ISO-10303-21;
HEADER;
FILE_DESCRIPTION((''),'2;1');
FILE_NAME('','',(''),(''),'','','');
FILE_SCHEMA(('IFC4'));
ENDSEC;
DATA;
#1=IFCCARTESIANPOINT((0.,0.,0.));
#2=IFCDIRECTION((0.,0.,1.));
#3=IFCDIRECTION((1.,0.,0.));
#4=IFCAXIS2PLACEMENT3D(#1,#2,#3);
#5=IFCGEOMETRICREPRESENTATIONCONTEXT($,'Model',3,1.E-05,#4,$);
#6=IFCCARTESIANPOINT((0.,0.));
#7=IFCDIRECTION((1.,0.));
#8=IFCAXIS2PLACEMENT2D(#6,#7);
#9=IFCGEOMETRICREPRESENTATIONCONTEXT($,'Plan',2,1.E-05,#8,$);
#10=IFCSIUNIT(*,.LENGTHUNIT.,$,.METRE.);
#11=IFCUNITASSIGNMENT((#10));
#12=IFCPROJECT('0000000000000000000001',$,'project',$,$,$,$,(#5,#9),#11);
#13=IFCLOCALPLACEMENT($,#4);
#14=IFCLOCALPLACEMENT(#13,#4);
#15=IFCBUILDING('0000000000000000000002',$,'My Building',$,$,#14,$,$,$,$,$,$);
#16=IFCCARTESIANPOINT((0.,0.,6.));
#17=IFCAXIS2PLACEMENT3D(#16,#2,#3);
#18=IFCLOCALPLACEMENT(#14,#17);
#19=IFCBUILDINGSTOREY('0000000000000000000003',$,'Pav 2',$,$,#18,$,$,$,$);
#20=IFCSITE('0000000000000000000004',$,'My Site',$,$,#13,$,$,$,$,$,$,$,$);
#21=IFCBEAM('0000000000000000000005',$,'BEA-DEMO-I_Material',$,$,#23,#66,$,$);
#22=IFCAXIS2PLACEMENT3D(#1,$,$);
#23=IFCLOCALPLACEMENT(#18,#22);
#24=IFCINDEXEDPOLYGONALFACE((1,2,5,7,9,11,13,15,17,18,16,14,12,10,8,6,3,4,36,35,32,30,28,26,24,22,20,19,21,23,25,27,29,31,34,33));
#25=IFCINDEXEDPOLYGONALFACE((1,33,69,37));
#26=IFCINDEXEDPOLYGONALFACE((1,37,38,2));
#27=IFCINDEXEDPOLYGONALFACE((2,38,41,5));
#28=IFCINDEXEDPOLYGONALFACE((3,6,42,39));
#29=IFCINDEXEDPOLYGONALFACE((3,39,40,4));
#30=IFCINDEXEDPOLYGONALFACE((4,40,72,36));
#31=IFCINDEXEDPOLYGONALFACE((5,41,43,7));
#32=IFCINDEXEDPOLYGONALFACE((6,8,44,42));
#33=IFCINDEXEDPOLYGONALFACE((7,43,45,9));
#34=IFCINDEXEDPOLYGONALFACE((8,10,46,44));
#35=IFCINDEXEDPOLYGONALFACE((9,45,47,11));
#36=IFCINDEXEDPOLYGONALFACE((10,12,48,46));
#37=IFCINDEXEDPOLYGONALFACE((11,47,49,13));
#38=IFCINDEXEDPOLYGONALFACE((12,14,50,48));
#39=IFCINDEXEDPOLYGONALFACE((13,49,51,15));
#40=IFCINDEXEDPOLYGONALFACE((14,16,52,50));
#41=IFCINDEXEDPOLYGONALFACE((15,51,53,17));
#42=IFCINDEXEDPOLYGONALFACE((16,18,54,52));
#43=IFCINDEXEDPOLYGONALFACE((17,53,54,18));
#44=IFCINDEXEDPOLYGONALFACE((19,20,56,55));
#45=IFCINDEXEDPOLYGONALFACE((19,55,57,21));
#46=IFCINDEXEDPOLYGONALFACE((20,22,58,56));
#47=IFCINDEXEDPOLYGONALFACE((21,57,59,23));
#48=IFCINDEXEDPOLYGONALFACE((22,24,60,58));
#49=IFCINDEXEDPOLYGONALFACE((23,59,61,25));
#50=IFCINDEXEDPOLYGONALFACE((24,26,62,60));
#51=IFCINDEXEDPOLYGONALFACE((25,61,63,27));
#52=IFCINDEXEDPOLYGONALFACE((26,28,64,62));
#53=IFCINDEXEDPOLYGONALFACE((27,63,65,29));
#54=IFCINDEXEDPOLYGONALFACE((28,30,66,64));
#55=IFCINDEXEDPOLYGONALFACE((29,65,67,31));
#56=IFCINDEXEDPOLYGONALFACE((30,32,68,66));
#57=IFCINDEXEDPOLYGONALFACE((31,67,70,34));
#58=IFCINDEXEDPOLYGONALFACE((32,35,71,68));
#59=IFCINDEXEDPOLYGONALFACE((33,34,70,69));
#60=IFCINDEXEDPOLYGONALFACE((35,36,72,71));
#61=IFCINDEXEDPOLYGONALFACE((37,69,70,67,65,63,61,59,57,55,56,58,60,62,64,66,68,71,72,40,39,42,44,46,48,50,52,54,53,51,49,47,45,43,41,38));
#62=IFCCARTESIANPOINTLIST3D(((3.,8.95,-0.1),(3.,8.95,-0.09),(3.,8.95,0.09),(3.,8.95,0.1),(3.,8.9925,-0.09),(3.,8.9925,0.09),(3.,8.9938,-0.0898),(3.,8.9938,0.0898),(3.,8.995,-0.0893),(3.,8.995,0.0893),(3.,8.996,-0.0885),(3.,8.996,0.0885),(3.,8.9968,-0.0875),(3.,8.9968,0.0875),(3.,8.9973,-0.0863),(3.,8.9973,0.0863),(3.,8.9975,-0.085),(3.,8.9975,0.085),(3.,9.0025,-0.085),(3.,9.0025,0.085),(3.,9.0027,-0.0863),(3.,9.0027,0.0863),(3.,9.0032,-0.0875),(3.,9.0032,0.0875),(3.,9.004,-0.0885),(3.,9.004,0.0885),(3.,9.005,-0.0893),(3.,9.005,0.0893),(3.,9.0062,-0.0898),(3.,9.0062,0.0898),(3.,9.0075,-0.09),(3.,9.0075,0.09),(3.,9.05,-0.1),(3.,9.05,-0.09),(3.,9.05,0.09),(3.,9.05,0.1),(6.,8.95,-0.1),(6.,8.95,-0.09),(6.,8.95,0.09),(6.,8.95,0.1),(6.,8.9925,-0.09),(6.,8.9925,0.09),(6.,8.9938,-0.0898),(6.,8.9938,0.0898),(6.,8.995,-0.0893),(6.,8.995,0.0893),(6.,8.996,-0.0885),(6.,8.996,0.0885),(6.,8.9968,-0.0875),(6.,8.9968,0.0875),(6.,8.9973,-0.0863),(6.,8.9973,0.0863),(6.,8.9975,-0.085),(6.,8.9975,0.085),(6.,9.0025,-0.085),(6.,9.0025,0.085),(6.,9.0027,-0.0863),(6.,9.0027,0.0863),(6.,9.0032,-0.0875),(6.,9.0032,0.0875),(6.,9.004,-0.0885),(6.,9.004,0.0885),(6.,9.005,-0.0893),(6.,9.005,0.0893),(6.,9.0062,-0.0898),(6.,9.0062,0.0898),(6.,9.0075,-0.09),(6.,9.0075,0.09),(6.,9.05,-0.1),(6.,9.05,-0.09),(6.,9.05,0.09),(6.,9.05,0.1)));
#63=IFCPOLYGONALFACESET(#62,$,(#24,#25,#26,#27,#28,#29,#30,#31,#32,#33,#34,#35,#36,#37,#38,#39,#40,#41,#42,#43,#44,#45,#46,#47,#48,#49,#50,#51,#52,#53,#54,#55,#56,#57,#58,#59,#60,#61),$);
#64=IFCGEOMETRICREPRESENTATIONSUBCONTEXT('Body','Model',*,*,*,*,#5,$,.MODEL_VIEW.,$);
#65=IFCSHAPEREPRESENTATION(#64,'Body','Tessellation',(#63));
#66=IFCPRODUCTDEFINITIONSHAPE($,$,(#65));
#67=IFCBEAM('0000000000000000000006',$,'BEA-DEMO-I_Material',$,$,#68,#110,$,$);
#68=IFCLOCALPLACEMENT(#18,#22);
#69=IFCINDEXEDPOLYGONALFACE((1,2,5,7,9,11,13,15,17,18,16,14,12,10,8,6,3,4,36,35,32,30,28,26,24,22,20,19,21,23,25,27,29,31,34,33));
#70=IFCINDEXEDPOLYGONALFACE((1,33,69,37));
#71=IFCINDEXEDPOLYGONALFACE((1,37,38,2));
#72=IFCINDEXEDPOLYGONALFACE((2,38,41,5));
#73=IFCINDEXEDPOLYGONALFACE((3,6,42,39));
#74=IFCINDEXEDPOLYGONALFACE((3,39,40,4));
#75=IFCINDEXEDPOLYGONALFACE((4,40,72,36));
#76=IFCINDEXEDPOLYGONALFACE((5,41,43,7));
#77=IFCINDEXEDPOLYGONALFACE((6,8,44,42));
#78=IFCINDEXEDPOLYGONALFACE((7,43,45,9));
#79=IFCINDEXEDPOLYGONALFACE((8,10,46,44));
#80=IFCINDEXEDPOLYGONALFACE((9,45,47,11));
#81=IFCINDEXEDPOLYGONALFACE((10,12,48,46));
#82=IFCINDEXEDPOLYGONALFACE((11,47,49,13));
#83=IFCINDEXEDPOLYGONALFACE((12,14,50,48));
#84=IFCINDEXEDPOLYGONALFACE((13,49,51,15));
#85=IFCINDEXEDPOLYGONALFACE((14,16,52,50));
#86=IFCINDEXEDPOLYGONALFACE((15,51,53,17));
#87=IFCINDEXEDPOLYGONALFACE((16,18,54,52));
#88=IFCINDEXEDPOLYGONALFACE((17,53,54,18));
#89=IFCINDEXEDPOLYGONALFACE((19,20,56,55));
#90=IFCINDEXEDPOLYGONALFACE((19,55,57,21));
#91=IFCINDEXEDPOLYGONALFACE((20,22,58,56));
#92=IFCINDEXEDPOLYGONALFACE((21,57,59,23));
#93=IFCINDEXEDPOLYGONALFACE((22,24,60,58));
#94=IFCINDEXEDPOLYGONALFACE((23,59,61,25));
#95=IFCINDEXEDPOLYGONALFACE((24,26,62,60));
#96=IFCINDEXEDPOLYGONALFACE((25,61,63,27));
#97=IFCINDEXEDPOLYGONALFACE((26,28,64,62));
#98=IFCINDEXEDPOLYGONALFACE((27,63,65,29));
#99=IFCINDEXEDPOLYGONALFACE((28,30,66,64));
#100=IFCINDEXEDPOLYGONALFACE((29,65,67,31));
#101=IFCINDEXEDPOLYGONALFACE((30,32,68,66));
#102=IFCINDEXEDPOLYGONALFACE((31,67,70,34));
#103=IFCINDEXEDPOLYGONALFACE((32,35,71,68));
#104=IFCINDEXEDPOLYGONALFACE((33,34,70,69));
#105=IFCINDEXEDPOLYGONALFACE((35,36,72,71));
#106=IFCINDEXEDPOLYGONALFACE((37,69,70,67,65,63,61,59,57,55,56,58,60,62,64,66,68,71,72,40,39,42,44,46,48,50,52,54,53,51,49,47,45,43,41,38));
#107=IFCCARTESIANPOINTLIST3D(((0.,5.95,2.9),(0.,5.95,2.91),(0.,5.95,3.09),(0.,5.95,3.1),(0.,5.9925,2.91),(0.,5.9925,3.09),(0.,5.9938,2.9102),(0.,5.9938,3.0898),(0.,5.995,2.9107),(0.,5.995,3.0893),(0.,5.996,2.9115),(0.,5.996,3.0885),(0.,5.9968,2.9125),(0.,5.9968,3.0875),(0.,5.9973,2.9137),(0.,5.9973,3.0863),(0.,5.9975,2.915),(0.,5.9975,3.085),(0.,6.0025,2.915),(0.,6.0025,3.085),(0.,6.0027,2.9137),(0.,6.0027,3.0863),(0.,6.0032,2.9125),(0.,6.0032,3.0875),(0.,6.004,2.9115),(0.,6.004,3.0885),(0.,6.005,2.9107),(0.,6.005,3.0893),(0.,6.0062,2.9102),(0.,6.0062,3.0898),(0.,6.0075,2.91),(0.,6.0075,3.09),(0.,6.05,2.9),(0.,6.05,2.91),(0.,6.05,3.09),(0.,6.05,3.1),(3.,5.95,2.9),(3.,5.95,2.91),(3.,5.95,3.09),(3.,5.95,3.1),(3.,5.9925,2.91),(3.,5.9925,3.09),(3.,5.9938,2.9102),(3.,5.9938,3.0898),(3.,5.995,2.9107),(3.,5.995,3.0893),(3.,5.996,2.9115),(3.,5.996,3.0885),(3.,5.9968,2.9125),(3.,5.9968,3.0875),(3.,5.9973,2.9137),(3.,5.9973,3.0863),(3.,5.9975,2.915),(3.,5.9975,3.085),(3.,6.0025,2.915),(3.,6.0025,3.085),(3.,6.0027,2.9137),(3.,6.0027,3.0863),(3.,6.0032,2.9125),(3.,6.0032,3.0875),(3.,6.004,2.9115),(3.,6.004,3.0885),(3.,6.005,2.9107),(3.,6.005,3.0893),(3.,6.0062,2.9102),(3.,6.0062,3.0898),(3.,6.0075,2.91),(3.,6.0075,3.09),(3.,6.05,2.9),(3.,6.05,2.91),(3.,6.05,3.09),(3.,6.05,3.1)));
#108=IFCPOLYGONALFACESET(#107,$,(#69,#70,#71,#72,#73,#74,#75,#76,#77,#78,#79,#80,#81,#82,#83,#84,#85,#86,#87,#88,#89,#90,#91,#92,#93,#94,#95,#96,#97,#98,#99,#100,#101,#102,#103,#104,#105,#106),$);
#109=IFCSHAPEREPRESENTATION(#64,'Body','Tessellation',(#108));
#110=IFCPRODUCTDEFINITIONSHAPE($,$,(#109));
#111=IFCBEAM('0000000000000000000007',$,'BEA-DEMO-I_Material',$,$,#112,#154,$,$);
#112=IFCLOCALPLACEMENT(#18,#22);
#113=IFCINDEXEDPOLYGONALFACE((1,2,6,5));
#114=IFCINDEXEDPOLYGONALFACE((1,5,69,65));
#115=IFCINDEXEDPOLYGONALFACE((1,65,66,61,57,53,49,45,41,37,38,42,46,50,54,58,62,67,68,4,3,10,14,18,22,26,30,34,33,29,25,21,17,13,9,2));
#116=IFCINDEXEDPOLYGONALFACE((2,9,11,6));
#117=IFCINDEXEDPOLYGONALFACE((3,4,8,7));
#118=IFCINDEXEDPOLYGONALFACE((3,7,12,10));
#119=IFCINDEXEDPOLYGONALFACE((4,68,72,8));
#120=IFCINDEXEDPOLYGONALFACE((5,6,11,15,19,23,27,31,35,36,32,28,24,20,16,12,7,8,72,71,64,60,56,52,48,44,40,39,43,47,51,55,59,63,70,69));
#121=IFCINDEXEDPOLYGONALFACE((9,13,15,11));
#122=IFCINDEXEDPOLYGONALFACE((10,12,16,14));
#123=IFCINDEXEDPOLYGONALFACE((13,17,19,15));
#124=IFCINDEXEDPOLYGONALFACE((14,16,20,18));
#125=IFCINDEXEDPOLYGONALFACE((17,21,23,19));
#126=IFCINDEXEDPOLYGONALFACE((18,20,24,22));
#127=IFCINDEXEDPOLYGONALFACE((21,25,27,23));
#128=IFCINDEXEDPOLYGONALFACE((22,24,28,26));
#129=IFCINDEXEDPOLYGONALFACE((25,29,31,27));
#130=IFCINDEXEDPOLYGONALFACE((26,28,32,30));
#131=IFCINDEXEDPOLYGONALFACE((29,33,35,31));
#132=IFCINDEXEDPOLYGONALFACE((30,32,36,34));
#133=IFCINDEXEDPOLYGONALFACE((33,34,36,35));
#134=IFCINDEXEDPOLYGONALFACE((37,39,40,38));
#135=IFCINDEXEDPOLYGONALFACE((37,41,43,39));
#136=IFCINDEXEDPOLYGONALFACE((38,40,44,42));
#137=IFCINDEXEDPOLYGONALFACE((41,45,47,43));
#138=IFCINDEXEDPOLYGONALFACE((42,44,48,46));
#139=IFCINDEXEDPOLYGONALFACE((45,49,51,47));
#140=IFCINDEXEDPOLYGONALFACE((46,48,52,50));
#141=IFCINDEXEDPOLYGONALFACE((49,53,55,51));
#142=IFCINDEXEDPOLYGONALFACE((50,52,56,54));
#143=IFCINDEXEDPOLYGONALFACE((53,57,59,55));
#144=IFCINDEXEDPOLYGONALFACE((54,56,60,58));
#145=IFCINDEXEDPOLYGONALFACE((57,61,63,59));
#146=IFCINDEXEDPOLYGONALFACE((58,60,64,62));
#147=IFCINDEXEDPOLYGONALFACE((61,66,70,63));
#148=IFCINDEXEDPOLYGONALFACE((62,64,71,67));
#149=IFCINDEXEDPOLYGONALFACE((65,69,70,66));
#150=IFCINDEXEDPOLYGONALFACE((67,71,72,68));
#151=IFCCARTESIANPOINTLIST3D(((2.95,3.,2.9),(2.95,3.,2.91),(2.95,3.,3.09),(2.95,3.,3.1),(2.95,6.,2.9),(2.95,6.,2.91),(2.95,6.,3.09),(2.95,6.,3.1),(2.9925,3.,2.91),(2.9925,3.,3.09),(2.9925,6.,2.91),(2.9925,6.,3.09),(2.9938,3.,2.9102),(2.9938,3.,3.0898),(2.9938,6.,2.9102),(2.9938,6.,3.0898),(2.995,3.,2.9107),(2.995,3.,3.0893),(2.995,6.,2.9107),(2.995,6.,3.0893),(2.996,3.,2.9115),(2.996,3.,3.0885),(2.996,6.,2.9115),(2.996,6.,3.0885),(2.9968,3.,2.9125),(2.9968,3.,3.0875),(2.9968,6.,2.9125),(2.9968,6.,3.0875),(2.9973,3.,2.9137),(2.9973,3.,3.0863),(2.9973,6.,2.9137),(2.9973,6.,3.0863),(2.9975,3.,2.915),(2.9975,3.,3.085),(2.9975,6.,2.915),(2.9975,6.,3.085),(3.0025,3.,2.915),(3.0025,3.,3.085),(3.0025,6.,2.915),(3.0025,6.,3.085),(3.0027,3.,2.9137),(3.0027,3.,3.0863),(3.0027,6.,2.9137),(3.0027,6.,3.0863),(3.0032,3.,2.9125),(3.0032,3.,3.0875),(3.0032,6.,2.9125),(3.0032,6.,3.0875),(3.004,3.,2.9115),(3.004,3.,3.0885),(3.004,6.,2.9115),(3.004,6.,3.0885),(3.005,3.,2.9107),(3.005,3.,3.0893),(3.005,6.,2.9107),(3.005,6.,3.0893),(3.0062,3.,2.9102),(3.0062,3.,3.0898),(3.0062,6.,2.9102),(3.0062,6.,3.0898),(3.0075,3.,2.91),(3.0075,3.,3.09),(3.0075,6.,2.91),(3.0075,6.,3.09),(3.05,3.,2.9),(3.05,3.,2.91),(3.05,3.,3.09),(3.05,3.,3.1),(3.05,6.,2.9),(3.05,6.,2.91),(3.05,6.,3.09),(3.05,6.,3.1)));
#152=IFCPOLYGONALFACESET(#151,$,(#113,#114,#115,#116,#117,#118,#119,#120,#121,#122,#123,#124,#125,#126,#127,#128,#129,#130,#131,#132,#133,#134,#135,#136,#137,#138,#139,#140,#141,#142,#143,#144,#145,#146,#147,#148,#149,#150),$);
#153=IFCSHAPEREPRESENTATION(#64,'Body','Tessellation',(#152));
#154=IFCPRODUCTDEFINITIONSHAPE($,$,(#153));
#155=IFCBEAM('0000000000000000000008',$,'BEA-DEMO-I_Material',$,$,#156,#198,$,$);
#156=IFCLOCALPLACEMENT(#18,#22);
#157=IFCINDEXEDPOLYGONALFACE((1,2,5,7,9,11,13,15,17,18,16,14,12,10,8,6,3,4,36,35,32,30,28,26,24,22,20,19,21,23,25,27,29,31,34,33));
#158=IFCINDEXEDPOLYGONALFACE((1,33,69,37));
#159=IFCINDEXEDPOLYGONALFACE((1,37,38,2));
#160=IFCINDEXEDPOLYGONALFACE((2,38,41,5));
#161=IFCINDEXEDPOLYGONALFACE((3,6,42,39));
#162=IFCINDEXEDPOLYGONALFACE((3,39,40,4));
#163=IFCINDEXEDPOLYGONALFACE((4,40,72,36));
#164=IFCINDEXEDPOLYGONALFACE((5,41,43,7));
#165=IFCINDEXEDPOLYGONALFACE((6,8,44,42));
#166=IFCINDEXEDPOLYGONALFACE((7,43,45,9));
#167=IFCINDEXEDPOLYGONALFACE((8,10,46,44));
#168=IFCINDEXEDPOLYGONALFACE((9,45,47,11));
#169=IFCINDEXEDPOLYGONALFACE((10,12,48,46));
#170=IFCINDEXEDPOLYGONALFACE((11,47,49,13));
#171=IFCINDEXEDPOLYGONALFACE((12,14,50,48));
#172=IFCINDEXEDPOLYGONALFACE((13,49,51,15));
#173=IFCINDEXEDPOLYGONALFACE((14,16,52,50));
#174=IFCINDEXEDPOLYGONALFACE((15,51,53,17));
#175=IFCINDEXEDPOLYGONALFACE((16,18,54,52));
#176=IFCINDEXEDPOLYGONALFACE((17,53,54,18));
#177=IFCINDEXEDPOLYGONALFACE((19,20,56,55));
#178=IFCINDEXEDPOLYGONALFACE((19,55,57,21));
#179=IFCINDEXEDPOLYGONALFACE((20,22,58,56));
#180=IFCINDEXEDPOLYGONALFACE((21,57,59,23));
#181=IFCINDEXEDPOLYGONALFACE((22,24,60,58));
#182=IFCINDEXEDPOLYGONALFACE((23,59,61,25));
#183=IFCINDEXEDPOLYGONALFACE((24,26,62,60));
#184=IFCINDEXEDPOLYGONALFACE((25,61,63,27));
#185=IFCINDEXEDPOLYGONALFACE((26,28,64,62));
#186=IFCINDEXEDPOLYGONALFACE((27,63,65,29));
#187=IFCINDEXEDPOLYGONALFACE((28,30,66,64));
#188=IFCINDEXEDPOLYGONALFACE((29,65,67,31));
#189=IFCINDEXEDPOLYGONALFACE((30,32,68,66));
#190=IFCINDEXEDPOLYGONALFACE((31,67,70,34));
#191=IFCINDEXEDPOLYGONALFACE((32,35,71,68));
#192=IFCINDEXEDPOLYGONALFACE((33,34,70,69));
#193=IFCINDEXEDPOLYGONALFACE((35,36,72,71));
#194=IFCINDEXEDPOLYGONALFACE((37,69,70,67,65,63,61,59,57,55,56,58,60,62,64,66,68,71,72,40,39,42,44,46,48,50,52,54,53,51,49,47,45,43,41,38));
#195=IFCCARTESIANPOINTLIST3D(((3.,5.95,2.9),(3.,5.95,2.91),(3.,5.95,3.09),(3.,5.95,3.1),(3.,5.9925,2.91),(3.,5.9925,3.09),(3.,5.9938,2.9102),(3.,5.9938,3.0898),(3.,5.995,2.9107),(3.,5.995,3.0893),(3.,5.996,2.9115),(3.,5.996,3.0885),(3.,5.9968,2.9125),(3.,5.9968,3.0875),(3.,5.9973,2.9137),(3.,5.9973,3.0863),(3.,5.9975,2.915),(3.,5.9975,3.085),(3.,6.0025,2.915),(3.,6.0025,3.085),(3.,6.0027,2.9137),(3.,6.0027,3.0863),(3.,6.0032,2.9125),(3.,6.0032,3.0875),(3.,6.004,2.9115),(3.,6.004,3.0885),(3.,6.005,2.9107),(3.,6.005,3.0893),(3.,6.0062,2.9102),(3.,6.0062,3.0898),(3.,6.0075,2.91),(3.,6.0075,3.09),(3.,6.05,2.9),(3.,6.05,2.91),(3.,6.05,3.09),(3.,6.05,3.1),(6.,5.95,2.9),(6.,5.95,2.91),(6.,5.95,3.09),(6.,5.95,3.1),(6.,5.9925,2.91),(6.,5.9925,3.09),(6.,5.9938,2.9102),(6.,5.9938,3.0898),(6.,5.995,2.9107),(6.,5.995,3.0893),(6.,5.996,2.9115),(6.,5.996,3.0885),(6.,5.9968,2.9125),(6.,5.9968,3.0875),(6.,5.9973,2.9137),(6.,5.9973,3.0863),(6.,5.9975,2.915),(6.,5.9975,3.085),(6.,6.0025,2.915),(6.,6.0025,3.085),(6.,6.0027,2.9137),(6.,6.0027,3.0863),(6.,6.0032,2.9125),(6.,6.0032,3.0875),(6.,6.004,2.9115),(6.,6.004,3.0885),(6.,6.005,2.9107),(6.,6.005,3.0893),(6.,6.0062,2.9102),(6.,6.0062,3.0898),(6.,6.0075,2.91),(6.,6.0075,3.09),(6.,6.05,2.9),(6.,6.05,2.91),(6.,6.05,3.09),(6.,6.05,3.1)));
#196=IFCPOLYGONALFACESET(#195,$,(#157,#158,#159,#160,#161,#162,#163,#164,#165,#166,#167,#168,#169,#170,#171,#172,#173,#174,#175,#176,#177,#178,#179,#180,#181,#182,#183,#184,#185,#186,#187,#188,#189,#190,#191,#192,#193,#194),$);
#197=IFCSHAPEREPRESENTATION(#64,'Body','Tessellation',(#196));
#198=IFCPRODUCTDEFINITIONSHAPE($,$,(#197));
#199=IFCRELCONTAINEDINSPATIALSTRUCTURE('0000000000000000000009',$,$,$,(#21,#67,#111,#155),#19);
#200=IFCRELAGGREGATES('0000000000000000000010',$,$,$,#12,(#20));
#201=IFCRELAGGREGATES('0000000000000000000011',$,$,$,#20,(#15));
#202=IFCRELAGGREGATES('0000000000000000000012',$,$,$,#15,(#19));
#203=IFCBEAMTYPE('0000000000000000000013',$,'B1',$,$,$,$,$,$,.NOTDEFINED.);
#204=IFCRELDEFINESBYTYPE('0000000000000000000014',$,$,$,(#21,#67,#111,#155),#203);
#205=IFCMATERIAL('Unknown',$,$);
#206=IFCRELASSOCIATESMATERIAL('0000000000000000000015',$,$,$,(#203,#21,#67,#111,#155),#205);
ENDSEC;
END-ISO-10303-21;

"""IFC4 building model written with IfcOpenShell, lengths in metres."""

from ifc_helpers import new_model, si_unit, frame, origin, origin_with_axes, origin_2d_with_axis, place, context, subcontext, project, spatial, i_section, extrude, material, material_profile, profile_set, profile_usage, type_object, element, save


model = new_model("IFC4")

# Units and contexts
model_context = context("Model", 3, precision=1e-05, world=origin_with_axes())
plan_context = context("Plan", 2, precision=1e-05, world=origin_2d_with_axis())
body_context = subcontext(model_context, "Body", "Model", "MODEL_VIEW")
ifc_project = project(units=[si_unit("LENGTHUNIT", "METRE")], contexts=[model_context, plan_context])

# Site, building, storey
site_placement = place(None, origin_with_axes())
site = spatial("IfcSite", under=ifc_project, at=site_placement, Name="My Site")
building_placement = place(site_placement, origin_with_axes())
building = spatial("IfcBuilding", under=site, at=building_placement, Name="My Building")
storey_placement = place(building_placement, frame((0.0, 0.0, 6.0), z_axis=(0.0, 0.0, 1.0), x_axis=(1.0, 0.0, 0.0)))
storey = spatial("IfcBuildingStorey", under=building, at=storey_placement, Name="Pav 2")

# Beams
ifc_material = material(Name="Unknown")
ifc_material_profile = material_profile(ifc_material, i_section(OverallWidth=0.1, OverallDepth=0.2, WebThickness=0.005, FlangeThickness=0.01, FilletRadius=0.005))
ifc_profile_set = profile_set([ifc_material_profile])
beam_type = type_object("IfcBeamType", Name="B1", PredefinedType="NOTDEFINED", material=ifc_profile_set)
ifc_profile_usage_1 = profile_usage(ifc_profile_set, cardinal=5)
beam_1_placement = place(storey_placement, frame((3.0, 9.0, 0.0), z_axis=(1.0, 0.0, 0.0), x_axis=(0.0, 1.0, 0.0)))
element("IfcBeam", 1, at=beam_1_placement, inside=storey, type_object=beam_type, material=ifc_profile_usage_1, Name="BEA-DEMO-I_Material", context=body_context, shape_type="SweptSolid", body=[
    extrude(i_section(OverallWidth=0.1, OverallDepth=0.2, WebThickness=0.005, FlangeThickness=0.01, FilletRadius=0.005), origin(), (0.0, 0.0, 1.0), 3.0),
])
ifc_profile_usage_2 = profile_usage(ifc_profile_set, cardinal=5)
beam_2_placement = place(storey_placement, frame((0.0, 6.0, 3.0), z_axis=(1.0, 0.0, 0.0), x_axis=(0.0, 1.0, 0.0)))
element("IfcBeam", 2, at=beam_2_placement, inside=storey, type_object=beam_type, material=ifc_profile_usage_2, Name="BEA-DEMO-I_Material", context=body_context, shape_type="SweptSolid", body=[
    extrude(i_section(OverallWidth=0.1, OverallDepth=0.2, WebThickness=0.005, FlangeThickness=0.01, FilletRadius=0.005), origin(), (0.0, 0.0, 1.0), 3.0),
])
ifc_profile_usage_3 = profile_usage(ifc_profile_set, cardinal=5)
beam_3_placement = place(storey_placement, frame((3.0, 6.0, 3.0), z_axis=(0.0, -1.0, 0.0), x_axis=(1.0, 0.0, 0.0)))
element("IfcBeam", 3, at=beam_3_placement, inside=storey, type_object=beam_type, material=ifc_profile_usage_3, Name="BEA-DEMO-I_Material", context=body_context, shape_type="SweptSolid", body=[
    extrude(i_section(OverallWidth=0.1, OverallDepth=0.2, WebThickness=0.005, FlangeThickness=0.01, FilletRadius=0.005), origin(), (0.0, 0.0, 1.0), 3.0),
])
ifc_profile_usage_4 = profile_usage(ifc_profile_set, cardinal=5)
beam_4_placement = place(storey_placement, frame((3.0, 6.0, 3.0), z_axis=(1.0, 0.0, 0.0), x_axis=(0.0, 1.0, 0.0)))
element("IfcBeam", 4, at=beam_4_placement, inside=storey, type_object=beam_type, material=ifc_profile_usage_4, Name="BEA-DEMO-I_Material", context=body_context, shape_type="SweptSolid", body=[
    extrude(i_section(OverallWidth=0.1, OverallDepth=0.2, WebThickness=0.005, FlangeThickness=0.01, FilletRadius=0.005), origin(), (0.0, 0.0, 1.0), 3.0),
])

save(model, "model.ifc")
